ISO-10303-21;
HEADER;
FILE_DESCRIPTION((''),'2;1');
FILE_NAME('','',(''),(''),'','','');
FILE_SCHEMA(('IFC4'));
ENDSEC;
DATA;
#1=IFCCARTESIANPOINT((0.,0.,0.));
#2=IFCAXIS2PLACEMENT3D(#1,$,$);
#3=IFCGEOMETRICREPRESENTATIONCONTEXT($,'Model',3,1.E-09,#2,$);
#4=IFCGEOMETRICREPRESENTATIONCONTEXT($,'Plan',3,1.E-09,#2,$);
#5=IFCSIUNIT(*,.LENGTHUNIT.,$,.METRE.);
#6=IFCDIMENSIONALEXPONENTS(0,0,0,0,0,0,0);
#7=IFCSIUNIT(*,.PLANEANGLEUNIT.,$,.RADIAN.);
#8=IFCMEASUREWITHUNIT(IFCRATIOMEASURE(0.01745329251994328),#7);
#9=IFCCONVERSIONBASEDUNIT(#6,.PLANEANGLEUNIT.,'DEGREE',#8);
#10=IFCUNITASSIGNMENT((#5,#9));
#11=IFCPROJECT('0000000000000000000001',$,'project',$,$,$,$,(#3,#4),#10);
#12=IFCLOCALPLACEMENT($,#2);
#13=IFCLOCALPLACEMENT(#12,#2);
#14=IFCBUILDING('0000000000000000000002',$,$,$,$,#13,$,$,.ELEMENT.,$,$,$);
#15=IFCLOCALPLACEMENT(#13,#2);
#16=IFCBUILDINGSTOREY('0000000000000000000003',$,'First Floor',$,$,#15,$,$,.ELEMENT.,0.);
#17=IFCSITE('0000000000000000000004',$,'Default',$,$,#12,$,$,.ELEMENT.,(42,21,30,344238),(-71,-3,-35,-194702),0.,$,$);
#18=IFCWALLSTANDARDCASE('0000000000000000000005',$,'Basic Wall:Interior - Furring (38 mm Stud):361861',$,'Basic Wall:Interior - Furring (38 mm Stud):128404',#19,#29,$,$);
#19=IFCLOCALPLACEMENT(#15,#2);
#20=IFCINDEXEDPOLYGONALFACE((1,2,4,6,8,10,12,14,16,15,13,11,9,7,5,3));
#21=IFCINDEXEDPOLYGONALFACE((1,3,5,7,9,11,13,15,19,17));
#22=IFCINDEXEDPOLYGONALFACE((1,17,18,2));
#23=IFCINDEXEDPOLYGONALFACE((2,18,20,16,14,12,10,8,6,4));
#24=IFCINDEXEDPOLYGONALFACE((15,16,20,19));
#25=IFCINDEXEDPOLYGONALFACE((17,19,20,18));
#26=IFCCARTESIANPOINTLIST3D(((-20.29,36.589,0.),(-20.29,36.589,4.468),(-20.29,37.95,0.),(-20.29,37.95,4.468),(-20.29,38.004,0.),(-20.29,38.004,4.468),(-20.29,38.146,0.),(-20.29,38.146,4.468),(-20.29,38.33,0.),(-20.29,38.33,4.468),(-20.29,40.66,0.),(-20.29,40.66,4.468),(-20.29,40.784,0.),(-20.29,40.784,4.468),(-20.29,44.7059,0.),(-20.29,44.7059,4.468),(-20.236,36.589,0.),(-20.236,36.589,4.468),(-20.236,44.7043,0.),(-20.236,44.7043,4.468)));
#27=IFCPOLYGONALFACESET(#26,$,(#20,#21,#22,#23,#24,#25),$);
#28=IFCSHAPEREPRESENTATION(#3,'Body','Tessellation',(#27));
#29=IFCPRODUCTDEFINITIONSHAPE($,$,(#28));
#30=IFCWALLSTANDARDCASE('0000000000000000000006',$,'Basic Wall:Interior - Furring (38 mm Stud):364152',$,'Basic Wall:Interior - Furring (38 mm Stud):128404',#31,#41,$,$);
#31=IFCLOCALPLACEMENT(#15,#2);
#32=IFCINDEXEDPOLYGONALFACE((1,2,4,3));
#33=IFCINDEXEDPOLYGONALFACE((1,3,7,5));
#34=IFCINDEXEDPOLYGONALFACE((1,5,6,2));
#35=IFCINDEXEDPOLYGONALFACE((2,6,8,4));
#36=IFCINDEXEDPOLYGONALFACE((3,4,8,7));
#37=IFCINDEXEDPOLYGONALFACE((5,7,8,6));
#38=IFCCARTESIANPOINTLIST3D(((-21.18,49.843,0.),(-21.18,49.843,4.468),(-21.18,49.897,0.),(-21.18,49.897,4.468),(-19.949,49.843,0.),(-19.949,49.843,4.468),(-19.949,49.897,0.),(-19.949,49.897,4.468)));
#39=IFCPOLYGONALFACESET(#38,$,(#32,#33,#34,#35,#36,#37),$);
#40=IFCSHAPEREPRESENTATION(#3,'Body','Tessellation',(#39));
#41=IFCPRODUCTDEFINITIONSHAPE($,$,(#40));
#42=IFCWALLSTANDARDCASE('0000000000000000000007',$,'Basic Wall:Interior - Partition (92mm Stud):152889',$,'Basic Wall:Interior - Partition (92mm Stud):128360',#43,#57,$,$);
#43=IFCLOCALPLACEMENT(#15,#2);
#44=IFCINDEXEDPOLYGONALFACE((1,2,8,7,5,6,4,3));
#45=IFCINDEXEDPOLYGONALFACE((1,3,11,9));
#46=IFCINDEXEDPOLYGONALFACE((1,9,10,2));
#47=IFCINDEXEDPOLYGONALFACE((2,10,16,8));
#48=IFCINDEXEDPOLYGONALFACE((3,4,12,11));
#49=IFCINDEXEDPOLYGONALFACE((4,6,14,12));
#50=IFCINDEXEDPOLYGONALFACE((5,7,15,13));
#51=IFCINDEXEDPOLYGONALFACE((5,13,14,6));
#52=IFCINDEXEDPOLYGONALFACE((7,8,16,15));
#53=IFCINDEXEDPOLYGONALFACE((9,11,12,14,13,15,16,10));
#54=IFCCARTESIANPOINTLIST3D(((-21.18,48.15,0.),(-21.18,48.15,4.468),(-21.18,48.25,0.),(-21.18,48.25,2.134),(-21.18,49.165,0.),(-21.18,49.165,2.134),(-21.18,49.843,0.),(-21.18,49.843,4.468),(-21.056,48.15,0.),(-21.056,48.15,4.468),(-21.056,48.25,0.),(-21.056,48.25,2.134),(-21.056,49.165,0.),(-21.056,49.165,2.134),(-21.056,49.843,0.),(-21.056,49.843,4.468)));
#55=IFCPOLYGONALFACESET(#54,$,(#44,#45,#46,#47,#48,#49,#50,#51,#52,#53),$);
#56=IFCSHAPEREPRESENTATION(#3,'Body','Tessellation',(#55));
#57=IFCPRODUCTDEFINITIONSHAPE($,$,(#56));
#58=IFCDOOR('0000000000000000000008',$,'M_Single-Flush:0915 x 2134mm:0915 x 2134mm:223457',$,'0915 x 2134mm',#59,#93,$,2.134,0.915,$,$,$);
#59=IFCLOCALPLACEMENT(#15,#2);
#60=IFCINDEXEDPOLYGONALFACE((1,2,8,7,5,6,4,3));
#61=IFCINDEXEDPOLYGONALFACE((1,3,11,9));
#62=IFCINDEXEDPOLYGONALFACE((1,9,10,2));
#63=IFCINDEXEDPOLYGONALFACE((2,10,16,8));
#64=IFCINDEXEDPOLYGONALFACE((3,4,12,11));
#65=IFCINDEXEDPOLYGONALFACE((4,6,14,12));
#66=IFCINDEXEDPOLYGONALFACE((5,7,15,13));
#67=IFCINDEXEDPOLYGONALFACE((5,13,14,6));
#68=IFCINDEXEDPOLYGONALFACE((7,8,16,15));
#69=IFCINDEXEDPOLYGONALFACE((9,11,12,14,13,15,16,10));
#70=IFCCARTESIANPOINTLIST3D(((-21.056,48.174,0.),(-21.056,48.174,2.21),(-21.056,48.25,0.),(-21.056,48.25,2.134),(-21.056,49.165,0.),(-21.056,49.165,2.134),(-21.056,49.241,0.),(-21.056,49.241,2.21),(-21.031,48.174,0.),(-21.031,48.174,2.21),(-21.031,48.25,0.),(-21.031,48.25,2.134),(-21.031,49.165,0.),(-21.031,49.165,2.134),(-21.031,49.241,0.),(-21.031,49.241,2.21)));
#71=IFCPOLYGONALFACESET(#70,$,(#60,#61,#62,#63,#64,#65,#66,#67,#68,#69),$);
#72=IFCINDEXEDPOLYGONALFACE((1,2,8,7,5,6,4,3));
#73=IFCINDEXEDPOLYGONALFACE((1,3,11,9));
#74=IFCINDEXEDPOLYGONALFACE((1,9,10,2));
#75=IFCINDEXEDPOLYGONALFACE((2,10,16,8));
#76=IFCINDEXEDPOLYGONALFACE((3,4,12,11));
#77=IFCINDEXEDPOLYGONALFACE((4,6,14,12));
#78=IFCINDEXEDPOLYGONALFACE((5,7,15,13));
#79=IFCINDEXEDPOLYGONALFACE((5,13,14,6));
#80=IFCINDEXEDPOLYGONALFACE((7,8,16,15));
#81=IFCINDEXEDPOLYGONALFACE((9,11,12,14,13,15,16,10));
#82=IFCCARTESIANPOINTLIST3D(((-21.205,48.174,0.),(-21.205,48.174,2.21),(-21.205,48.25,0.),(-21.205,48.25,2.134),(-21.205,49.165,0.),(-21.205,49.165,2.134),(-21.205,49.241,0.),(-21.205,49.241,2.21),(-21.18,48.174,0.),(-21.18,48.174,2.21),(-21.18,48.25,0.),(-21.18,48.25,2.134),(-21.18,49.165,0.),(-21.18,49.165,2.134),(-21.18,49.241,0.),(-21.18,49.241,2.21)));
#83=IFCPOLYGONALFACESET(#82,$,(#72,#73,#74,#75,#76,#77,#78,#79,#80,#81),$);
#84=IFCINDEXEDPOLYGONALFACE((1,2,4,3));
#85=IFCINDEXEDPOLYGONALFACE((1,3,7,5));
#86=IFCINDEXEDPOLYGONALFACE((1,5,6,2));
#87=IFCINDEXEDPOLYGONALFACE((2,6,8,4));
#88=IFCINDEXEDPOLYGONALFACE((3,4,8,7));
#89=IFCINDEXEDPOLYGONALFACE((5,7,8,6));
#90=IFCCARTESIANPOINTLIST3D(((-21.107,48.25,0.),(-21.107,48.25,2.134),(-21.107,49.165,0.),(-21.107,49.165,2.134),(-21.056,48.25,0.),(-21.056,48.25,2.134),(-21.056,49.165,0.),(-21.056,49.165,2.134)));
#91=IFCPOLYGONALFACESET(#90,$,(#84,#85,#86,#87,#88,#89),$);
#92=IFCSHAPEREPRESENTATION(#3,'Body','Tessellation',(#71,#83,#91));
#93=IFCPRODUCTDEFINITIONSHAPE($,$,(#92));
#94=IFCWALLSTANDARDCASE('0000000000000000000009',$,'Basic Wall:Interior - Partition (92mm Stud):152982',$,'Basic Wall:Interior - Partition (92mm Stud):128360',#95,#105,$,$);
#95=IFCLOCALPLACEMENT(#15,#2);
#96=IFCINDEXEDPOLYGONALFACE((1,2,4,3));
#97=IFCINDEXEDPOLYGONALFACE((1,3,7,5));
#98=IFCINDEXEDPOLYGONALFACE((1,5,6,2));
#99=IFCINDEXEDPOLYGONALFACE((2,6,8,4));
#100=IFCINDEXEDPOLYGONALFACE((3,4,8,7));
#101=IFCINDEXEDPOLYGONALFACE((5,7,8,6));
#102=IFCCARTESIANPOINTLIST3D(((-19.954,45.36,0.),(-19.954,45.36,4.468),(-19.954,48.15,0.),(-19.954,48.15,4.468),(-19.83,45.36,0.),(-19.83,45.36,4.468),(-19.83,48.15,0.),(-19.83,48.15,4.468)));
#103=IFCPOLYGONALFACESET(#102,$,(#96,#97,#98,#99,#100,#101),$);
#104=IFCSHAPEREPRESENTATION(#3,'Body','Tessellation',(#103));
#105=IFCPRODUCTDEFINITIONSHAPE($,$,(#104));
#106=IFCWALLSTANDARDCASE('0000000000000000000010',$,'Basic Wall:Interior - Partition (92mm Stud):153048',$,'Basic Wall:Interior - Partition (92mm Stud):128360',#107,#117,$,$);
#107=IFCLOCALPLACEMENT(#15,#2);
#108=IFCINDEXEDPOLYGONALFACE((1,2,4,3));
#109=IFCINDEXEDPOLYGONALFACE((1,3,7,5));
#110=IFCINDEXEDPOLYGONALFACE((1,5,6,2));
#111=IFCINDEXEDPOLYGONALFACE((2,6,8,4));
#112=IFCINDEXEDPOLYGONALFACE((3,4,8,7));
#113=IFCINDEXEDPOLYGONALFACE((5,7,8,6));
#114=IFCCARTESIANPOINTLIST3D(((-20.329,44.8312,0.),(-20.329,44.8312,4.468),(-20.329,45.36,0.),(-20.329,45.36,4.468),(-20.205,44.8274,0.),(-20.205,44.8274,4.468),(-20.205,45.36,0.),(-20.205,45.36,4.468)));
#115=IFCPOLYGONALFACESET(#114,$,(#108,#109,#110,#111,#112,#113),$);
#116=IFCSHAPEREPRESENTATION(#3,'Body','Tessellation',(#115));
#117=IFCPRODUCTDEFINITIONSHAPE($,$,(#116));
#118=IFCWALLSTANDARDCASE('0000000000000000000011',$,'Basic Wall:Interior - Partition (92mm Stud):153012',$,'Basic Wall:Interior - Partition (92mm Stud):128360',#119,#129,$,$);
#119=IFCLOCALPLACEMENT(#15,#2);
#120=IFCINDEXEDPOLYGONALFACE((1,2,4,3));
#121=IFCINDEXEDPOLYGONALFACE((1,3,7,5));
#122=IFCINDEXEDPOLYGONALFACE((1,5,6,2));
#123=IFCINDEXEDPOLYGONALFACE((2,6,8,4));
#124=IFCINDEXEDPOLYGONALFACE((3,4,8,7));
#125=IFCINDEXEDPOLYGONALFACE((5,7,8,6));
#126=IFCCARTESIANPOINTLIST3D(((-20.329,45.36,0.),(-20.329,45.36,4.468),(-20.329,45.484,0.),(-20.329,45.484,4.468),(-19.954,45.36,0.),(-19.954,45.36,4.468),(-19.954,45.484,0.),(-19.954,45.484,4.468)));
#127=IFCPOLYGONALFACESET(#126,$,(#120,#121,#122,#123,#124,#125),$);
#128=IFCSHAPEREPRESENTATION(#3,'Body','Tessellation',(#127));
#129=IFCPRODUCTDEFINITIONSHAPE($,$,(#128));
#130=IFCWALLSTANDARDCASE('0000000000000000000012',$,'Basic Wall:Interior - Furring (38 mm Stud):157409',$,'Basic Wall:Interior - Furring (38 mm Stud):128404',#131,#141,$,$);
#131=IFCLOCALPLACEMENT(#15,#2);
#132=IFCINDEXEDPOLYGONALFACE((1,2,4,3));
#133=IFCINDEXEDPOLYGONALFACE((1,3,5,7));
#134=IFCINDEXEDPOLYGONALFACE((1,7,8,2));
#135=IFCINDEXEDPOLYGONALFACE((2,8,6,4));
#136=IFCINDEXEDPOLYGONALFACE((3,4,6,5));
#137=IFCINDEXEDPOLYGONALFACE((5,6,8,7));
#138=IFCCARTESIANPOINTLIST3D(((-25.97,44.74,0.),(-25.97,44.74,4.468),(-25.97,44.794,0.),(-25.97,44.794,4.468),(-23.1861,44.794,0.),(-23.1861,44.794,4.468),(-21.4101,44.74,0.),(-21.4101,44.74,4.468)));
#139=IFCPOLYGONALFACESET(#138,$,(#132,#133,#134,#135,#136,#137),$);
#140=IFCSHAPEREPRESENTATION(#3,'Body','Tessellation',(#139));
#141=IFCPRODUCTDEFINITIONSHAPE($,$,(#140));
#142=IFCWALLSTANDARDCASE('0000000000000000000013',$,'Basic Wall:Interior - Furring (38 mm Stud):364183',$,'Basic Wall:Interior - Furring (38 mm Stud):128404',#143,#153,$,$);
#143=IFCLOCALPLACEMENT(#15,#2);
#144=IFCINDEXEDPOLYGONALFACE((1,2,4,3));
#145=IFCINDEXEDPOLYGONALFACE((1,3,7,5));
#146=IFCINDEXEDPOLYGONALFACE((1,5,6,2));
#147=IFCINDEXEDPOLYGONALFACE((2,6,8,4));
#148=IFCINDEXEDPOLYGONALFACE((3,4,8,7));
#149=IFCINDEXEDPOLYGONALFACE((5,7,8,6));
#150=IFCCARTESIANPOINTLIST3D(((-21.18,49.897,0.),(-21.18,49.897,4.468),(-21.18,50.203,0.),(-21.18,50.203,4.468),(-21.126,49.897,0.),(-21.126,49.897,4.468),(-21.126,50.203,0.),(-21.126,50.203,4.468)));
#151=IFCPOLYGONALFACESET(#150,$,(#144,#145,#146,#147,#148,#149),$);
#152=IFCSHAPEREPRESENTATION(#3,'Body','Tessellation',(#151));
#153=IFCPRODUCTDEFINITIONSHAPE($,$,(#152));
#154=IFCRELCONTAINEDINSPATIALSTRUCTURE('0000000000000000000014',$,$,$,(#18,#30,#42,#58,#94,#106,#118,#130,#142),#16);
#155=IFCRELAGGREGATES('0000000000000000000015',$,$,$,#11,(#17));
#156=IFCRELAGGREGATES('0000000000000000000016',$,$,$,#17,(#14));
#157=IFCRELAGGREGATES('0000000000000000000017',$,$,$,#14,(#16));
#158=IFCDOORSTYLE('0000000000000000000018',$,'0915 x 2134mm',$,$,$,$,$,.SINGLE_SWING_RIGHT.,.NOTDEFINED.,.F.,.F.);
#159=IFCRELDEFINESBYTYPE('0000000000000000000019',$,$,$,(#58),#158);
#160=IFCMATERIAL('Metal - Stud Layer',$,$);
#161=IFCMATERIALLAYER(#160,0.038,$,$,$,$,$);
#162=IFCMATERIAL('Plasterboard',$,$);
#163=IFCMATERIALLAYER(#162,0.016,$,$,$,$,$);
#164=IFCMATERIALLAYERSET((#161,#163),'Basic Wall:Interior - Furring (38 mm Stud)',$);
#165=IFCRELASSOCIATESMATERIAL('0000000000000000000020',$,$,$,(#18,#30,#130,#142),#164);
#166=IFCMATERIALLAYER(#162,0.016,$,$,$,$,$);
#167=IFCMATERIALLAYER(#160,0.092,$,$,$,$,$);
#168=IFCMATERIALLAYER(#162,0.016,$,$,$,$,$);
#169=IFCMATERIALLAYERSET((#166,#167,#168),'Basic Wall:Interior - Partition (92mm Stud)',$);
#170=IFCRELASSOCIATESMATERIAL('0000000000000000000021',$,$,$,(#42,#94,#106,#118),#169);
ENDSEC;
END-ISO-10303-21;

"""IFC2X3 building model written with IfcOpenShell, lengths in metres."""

from ifc_helpers import new_model, entity, si_unit, converted_unit, frame, frame_2d, origin, origin_2d_with_axis, place, context, project, spatial, polyline, rectangle, outline, extrude, clip, bounded_halfspace, source, transform, mapped, material, layer, layer_set, layer_usage, type_object, type_shapes, element, fill, save


model = new_model("IFC2X3")

# Units and contexts
model_context = context("Model", 3, precision=1e-09, world=origin())
plan_context = context("Plan", 3, precision=1e-09, world=origin())
ifc_project = project(units=[si_unit("LENGTHUNIT", "METRE"), converted_unit("PLANEANGLEUNIT", "DEGREE", entity("IfcRatioMeasure", 0.01745329251994328), si_unit("PLANEANGLEUNIT", "RADIAN"), dimensions=[0, 0, 0, 0, 0, 0, 0])], contexts=[model_context, plan_context])

# Site, building, storey
site_placement = place(None, origin())
site = spatial("IfcSite", under=ifc_project, at=site_placement, Name="Default", CompositionType="ELEMENT", RefLatitude=(42, 21, 30, 344238), RefLongitude=(-71, -3, -35, -194702), RefElevation=0.0)
building_placement = place(site_placement, origin())
building = spatial("IfcBuilding", under=site, at=building_placement, CompositionType="ELEMENT")
storey_placement = place(building_placement, origin())
storey = spatial("IfcBuildingStorey", under=building, at=storey_placement, Name="First Floor", CompositionType="ELEMENT", Elevation=0.0)

# Walls
ifc_material_1 = material(Name="Metal - Stud Layer")
ifc_layer_1 = layer(ifc_material_1, 0.038)
ifc_material_2 = material(Name="Plasterboard")
ifc_layer_2 = layer(ifc_material_2, 0.016)
ifc_layer_set_1 = layer_set([ifc_layer_1, ifc_layer_2], Name="Basic Wall:Interior - Furring (38 mm Stud)")
ifc_layer_usage_1 = layer_usage(ifc_layer_set_1, "AXIS2", "NEGATIVE", 0.027)
wall_1_placement = place(storey_placement, frame((-20.263, 44.7059, 0.0), z_axis=(0.0, 0.0, 1.0), x_axis=(0.0, -1.0, 0.0)))
element("IfcWallStandardCase", 1, at=wall_1_placement, inside=storey, material=ifc_layer_usage_1, Name="Basic Wall:Interior - Furring (38 mm Stud):361861", ObjectType="Basic Wall:Interior - Furring (38 mm Stud):128404", context=model_context, shape_type="SweptSolid", body=[
    extrude(outline(polyline([(8.1169, -0.027), (8.1169, 0.027), (0.0016, 0.027), (0.0, -0.027), (3.9219, -0.027), (4.0459, -0.027), (6.3759, -0.027), (6.5599, -0.027), (6.7019, -0.027), (6.7559, -0.027), (8.1169, -0.027)])), origin(), (0.0, 0.0, 1.0), 4.468),
])
ifc_layer_usage_2 = layer_usage(ifc_layer_set_1, "AXIS2", "POSITIVE", -0.027)
wall_2_placement = place(storey_placement, frame((-19.949, 49.87, 0.0), z_axis=(0.0, 0.0, 1.0), x_axis=(-1.0, 0.0, 0.0)))
element("IfcWallStandardCase", 2, at=wall_2_placement, inside=storey, material=ifc_layer_usage_2, Name="Basic Wall:Interior - Furring (38 mm Stud):364152", ObjectType="Basic Wall:Interior - Furring (38 mm Stud):128404", context=model_context, shape_type="SweptSolid", body=[
    extrude(rectangle(XDim=1.231, YDim=0.054, at=frame_2d((0.6155, 0.0), x_axis=(-1.0, 0.0))), origin(), (0.0, 0.0, 1.0), 4.468),
])

# Wall, opening, door
ifc_layer_3 = layer(ifc_material_2, 0.016)
ifc_layer_4 = layer(ifc_material_1, 0.092)
ifc_layer_5 = layer(ifc_material_2, 0.016)
ifc_layer_set_2 = layer_set([ifc_layer_3, ifc_layer_4, ifc_layer_5], Name="Basic Wall:Interior - Partition (92mm Stud)")
ifc_layer_usage_3 = layer_usage(ifc_layer_set_2, "AXIS2", "NEGATIVE", 0.062)
wall_3_placement = place(storey_placement, frame((-21.118, 48.15, 0.0), z_axis=(0.0, 0.0, 1.0), x_axis=(0.0, 1.0, 0.0)))
wall_3 = element("IfcWallStandardCase", 3, at=wall_3_placement, inside=storey, material=ifc_layer_usage_3, Name="Basic Wall:Interior - Partition (92mm Stud):152889", ObjectType="Basic Wall:Interior - Partition (92mm Stud):128360", context=model_context, shape_type="SweptSolid", body=[
    extrude(rectangle(XDim=1.693, YDim=0.124, at=frame_2d((0.8465, 0.0), x_axis=(-1.0, 0.0))), origin(), (0.0, 0.0, 1.0), 4.468),
])
opening_1_placement = place(wall_3_placement, frame((1.015, 0.062, 0.0)))
opening_1 = element("IfcOpeningElement", 4, at=opening_1_placement, cuts=wall_3, ObjectType="Opening", context=model_context, shape_type="SweptSolid", body=[
    extrude(rectangle(XDim=0.915, YDim=2.134, at=frame_2d((1.067, 0.4575), x_axis=(0.0, 1.0))), frame((0.0, 0.0, 0.0), z_axis=(0.0, -1.0, 0.0), x_axis=(0.0, 0.0, 1.0)), (0.0, 0.0, 1.0), 0.124),
])
door_style_1 = type_object("IfcDoorStyle", Name="0915 x 2134mm", ConstructionType="NOTDEFINED", OperationType="SINGLE_SWING_RIGHT", ParameterTakesPrecedence=False, Sizeable=False)
shared_shape_1 = source(origin(), model_context, "Body", "SweptSolid", [
    extrude(outline(polyline([(-0.5335, -1.124), (0.5335, -1.124), (0.5335, 1.086), (0.4575, 1.086), (0.4575, -1.048), (-0.4575, -1.048), (-0.4575, 1.086), (-0.5335, 1.086), (-0.5335, -1.124)])), frame((0.4575, 0.124, 1.086), z_axis=(0.0, 1.0, 0.0), x_axis=(1.0, 0.0, 0.0)), (0.0, 0.0, 1.0), 0.025),
    extrude(outline(polyline([(-1.124, -0.5335), (1.086, -0.5335), (1.086, -0.4575), (-1.048, -0.4575), (-1.048, 0.4575), (1.086, 0.4575), (1.086, 0.5335), (-1.124, 0.5335), (-1.124, -0.5335)])), frame((0.4575, -0.025, 1.086), z_axis=(0.0, 1.0, 0.0), x_axis=(0.0, 0.0, -1.0)), (0.0, 0.0, 1.0), 0.025),
    extrude(rectangle(XDim=0.051, YDim=0.915, at=origin_2d_with_axis()), frame((0.4575, 0.0985, 0.0), z_axis=(0.0, 0.0, 1.0), x_axis=(0.0, 1.0, 0.0)), (0.0, 0.0, 1.0), 2.134),
])
type_shapes(door_style_1, [shared_shape_1])
door_1_placement = place(opening_1_placement, frame((0.0, 0.0, 0.0), z_axis=(0.0, 0.0, 1.0), x_axis=(-1.0, 0.0, 0.0)))
door_1 = element("IfcDoor", 5, at=door_1_placement, inside=storey, type_object=door_style_1, Name="M_Single-Flush:0915 x 2134mm:0915 x 2134mm:223457", ObjectType="0915 x 2134mm", OverallHeight=2.134, OverallWidth=0.915, context=model_context, shape_type="MappedRepresentation", body=[
    mapped(shared_shape_1, transform((0.0, 0.0, 0.0), scale=1.0)),
])
fill(opening_1, door_1)

# Walls
wall_4_placement = place(storey_placement, frame((-19.892, 48.15, 0.0), z_axis=(0.0, 0.0, 1.0), x_axis=(0.0, -1.0, 0.0)))
element("IfcWallStandardCase", 6, at=wall_4_placement, inside=storey, material=ifc_layer_usage_3, Name="Basic Wall:Interior - Partition (92mm Stud):152982", ObjectType="Basic Wall:Interior - Partition (92mm Stud):128360", context=model_context, shape_type="SweptSolid", body=[
    extrude(rectangle(XDim=2.79, YDim=0.124, at=frame_2d((1.395, 0.0), x_axis=(-1.0, 0.0))), origin(), (0.0, 0.0, 1.0), 4.468),
])
wall_5_placement = place(storey_placement, frame((-20.267, 45.36, 0.0), z_axis=(0.0, 0.0, 1.0), x_axis=(0.0, -1.0, 0.0)))
element("IfcWallStandardCase", 7, at=wall_5_placement, inside=storey, material=ifc_layer_usage_3, Name="Basic Wall:Interior - Partition (92mm Stud):153048", ObjectType="Basic Wall:Interior - Partition (92mm Stud):128360", context=model_context, shape_type="SweptSolid", body=[
    extrude(outline(polyline([(0.5288, -0.062), (0.5326, 0.062), (0.0, 0.062), (0.0, -0.062), (0.5288, -0.062)])), origin(), (0.0, 0.0, 1.0), 4.468),
])
wall_6_placement = place(storey_placement, frame((-19.954, 45.422, 0.0), z_axis=(0.0, 0.0, 1.0), x_axis=(-1.0, 0.0, 0.0)))
element("IfcWallStandardCase", 8, at=wall_6_placement, inside=storey, material=ifc_layer_usage_3, Name="Basic Wall:Interior - Partition (92mm Stud):153012", ObjectType="Basic Wall:Interior - Partition (92mm Stud):128360", context=model_context, shape_type="SweptSolid", body=[
    extrude(rectangle(XDim=0.375, YDim=0.124, at=frame_2d((0.1875, 0.0), x_axis=(-1.0, 0.0))), origin(), (0.0, 0.0, 1.0), 4.468),
])
wall_7_placement = place(storey_placement, frame((-21.4101, 44.767, 0.0), z_axis=(0.0, 0.0, 1.0), x_axis=(-1.0, 0.0, 0.0)))
element("IfcWallStandardCase", 9, at=wall_7_placement, inside=storey, material=ifc_layer_usage_2, Name="Basic Wall:Interior - Furring (38 mm Stud):157409", ObjectType="Basic Wall:Interior - Furring (38 mm Stud):128404", context=model_context, shape_type="Clipping", body=[
    clip(extrude(rectangle(XDim=4.5599, YDim=0.054, at=frame_2d((2.2799, 0.0), x_axis=(-1.0, 0.0))), origin(), (0.0, 0.0, 1.0), 4.468), bounded_halfspace(frame((1.776, -0.027, 0.0), z_axis=(0.030391, 0.999538, 0.0), x_axis=(-0.999538, 0.030391, 0.0)), True, frame((1.776, -0.027, 0.0), z_axis=(0.030391, 0.999538, 0.0), x_axis=(-0.999538, 0.030391, 0.0)), polyline([(0.0, 0.0), (1.7768, 0.0), (1.7768, 4.468), (0.0, 4.468), (0.0, 0.0)]))),
])
wall_8_placement = place(storey_placement, frame((-21.153, 49.897, 0.0), z_axis=(0.0, 0.0, 1.0), x_axis=(0.0, 1.0, 0.0)))
element("IfcWallStandardCase", 10, at=wall_8_placement, inside=storey, material=ifc_layer_usage_2, Name="Basic Wall:Interior - Furring (38 mm Stud):364183", ObjectType="Basic Wall:Interior - Furring (38 mm Stud):128404", context=model_context, shape_type="SweptSolid", body=[
    extrude(rectangle(XDim=0.306, YDim=0.054, at=frame_2d((0.153, 0.0), x_axis=(-1.0, 0.0))), origin(), (0.0, 0.0, 1.0), 4.468),
])

save(model, "model.ifc")
